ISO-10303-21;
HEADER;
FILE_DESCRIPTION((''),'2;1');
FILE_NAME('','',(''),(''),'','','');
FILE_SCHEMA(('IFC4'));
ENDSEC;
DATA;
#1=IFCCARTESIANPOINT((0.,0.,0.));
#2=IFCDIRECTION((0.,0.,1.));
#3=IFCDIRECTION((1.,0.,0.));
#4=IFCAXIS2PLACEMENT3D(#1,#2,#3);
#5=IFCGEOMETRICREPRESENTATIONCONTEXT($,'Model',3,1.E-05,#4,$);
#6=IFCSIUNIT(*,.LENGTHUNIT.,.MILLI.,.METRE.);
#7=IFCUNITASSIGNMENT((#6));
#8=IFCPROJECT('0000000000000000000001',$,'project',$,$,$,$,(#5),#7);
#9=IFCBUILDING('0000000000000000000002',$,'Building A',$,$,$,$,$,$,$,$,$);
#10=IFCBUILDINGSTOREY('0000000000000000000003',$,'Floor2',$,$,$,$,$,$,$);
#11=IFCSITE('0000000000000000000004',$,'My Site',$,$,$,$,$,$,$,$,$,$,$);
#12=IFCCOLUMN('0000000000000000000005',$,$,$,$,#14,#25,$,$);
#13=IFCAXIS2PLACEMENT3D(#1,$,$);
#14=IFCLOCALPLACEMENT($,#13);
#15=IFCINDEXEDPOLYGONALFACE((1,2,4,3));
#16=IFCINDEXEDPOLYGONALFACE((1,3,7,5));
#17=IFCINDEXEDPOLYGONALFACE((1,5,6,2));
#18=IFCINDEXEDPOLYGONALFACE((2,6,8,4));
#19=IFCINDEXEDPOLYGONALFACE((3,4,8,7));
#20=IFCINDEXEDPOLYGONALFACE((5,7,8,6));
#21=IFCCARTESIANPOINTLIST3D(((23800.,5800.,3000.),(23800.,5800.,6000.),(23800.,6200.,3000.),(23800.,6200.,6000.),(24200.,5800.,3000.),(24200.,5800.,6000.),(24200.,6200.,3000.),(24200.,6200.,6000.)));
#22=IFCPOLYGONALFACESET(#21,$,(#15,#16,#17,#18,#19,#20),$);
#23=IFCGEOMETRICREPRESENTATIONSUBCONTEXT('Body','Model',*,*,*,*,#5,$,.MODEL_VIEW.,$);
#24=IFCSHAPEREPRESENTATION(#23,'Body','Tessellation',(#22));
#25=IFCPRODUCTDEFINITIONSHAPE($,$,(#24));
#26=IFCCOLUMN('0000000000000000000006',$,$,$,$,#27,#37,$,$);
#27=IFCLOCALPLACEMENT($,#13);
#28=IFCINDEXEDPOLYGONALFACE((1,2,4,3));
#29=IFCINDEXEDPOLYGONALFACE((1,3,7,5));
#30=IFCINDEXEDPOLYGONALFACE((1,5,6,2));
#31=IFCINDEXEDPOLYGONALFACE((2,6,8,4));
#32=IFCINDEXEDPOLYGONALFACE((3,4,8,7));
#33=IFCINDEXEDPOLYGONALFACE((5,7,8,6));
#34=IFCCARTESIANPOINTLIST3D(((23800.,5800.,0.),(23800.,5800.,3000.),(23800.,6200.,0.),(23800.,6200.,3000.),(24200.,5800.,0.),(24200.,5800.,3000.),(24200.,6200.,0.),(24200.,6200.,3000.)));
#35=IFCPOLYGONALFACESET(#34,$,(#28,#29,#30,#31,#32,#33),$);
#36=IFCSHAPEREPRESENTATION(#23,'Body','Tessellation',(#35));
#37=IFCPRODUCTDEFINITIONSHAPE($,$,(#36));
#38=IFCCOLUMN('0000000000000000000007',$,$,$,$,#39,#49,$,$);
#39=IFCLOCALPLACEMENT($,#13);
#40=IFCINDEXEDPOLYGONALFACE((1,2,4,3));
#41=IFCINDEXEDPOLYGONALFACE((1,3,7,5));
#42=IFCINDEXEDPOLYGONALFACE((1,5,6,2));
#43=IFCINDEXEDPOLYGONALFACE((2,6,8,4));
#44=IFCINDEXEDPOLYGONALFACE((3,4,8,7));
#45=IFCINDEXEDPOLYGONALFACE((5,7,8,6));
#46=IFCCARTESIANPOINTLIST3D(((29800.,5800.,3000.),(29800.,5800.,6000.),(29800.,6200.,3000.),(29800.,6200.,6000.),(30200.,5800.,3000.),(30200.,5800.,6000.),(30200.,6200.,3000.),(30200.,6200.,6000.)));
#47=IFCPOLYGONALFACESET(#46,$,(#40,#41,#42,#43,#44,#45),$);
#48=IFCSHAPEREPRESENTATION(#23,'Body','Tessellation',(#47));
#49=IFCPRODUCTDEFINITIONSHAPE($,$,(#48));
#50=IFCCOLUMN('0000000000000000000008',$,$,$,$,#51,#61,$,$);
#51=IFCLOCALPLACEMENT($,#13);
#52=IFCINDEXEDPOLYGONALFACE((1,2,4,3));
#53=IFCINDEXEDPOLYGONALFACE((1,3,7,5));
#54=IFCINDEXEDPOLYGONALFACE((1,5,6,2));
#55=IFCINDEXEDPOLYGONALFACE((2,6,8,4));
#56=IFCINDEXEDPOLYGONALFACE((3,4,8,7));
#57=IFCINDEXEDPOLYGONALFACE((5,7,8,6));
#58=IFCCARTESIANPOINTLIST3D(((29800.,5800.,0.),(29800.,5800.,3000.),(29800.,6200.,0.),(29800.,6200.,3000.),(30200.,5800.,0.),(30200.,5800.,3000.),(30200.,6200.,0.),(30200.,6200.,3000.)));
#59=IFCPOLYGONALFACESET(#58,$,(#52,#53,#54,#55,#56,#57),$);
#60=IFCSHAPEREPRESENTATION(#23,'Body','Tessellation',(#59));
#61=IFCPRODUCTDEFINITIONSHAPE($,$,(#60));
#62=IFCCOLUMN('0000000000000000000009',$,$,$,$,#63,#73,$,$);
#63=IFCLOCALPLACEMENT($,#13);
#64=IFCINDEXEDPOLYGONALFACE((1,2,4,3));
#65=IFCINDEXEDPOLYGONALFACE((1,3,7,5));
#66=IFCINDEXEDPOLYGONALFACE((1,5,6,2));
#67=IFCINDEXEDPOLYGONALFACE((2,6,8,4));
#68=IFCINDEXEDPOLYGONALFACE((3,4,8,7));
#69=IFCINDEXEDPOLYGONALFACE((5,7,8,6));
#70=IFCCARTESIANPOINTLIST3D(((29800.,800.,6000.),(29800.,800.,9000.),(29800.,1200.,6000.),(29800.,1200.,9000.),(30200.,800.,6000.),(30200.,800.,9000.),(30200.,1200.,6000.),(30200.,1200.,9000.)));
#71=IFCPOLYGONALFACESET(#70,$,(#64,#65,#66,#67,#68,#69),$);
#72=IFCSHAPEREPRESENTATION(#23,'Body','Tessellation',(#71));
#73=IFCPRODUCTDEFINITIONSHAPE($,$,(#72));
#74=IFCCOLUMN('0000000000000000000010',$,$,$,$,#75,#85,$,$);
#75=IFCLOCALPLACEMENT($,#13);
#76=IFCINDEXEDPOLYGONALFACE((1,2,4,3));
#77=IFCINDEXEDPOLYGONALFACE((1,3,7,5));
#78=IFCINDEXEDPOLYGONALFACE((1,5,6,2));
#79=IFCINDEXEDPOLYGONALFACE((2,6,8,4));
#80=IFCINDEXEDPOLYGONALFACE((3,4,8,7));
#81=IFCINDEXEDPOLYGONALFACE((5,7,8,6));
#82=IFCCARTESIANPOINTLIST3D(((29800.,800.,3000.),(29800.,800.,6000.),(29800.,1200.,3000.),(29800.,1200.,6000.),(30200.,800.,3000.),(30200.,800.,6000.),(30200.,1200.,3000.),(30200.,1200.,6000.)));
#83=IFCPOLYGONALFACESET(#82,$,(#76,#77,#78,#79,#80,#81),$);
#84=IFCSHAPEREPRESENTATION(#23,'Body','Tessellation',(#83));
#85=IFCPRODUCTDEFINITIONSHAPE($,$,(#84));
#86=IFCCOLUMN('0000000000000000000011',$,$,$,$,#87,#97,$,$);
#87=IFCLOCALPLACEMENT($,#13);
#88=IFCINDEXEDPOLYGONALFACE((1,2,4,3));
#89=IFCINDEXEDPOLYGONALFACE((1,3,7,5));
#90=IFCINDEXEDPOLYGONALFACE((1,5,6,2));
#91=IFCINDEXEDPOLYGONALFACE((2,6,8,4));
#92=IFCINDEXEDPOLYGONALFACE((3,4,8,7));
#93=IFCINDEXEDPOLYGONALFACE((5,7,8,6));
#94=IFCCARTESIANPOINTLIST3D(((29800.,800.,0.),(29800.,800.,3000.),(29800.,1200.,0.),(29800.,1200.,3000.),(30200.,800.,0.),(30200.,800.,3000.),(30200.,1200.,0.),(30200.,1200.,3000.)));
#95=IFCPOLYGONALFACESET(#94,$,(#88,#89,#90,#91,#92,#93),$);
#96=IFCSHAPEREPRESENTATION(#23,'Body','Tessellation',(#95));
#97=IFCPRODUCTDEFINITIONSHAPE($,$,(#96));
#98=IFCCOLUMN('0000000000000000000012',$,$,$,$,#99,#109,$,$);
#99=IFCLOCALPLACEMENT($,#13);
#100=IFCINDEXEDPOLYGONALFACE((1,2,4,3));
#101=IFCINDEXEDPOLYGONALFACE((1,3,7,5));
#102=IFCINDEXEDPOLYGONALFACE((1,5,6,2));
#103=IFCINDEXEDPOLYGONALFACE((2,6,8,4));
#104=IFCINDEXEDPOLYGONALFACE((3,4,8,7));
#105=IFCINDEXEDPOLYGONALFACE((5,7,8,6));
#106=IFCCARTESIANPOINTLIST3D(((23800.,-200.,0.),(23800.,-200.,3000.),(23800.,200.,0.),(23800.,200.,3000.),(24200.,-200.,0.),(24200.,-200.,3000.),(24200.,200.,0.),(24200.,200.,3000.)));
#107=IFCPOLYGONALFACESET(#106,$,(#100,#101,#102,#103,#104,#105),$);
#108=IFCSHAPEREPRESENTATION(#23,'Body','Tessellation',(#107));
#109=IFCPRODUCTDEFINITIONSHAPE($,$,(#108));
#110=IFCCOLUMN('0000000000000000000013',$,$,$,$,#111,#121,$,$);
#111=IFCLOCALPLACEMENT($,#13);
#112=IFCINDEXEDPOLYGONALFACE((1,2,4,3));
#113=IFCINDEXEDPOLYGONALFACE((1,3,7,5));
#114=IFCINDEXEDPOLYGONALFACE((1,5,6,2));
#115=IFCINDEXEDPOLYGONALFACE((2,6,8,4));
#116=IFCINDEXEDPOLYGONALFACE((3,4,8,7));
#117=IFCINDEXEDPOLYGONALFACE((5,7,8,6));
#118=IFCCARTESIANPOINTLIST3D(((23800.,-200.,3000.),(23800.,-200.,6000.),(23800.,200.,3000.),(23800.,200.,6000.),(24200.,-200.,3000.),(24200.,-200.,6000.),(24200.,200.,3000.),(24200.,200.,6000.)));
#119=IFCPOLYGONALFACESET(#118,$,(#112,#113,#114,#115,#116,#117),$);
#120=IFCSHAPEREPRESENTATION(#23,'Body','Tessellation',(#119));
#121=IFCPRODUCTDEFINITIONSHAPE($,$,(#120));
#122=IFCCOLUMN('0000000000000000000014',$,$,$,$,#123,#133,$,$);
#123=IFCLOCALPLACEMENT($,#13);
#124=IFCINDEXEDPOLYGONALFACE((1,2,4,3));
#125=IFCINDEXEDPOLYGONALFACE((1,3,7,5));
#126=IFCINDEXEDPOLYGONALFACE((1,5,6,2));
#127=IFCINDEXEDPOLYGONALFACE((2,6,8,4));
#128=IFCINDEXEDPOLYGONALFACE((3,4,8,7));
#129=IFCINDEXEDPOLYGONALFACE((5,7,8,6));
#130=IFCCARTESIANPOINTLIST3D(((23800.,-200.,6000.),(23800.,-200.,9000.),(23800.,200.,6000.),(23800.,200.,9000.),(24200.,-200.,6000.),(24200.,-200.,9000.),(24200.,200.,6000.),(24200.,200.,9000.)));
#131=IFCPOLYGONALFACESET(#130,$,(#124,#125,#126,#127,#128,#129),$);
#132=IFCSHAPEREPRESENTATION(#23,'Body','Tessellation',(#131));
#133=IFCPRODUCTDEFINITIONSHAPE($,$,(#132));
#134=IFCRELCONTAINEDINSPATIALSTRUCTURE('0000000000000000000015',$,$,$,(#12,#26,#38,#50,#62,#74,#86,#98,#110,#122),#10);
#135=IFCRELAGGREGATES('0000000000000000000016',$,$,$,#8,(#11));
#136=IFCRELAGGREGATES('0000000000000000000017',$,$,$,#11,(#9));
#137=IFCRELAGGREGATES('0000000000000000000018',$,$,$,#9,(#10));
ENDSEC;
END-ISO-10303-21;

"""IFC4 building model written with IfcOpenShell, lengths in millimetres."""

from ifc_helpers import new_model, si_unit, frame, origin_with_axes, place, context, subcontext, project, spatial, line, indexed_curve, outline, extrude, element, save


model = new_model("IFC4")

# Units and contexts
model_context = context("Model", 3, precision=1e-05, world=origin_with_axes())
body_context = subcontext(model_context, "Body", "Model", "MODEL_VIEW")
ifc_project = project(units=[si_unit("LENGTHUNIT", "METRE", prefix="MILLI")], contexts=[model_context])

# Site, building, storey
site = spatial("IfcSite", under=ifc_project, Name="My Site")
building = spatial("IfcBuilding", under=site, Name="Building A")
storey = spatial("IfcBuildingStorey", under=building, Name="Floor2")

# Columns
for number, where, z_axis, x_axis in (
    (1, (24000.0, 6000.0, 3000.0), (0.0, 0.0, 1.0), (1.0, 0.0, 0.0)),
    (2, (24000.0, 6000.0, 0.0), (0.0, 0.0, 1.0), (1.0, 0.0, 0.0)),
    (3, (30000.0, 6000.0, 3000.0), (0.0, 0.0, 1.0), (1.0, 0.0, 0.0)),
    (4, (30000.0, 6000.0, 0.0), (0.0, 0.0, 1.0), (1.0, 0.0, 0.0)),
    (5, (30000.0, 1000.0, 6000.0), (0.0, 0.0, 1.0), (1.0, 0.0, 0.0)),
    (6, (30000.0, 1000.0, 3000.0), (0.0, 0.0, 1.0), (1.0, 0.0, 0.0)),
    (7, (30000.0, 1000.0, 0.0), (0.0, 0.0, 1.0), (1.0, 0.0, 0.0)),
    (8, (24000.0, 0.0, 0.0), (0.0, 0.0, 1.0), (1.0, 0.0, 0.0)),
    (9, (24000.0, 0.0, 3000.0), (0.0, 0.0, 1.0), (1.0, 0.0, 0.0)),
    (10, (24000.0, 0.0, 6000.0), (0.0, 0.0, 1.0), (1.0, 0.0, 0.0)),
):
    element("IfcColumn", number, at=place(None, frame(where, z_axis=z_axis, x_axis=x_axis)), inside=storey, context=body_context, shape_type="SweptSolid", body=[
        extrude(outline(indexed_curve([(-200.0, -200.0), (200.0, -200.0), (200.0, 200.0), (-200.0, 200.0)], segments=[line(1, 2, 3, 4, 1)])), origin_with_axes(), (0.0, 0.0, 1.0), 3000.0),
    ])

save(model, "model.ifc")
